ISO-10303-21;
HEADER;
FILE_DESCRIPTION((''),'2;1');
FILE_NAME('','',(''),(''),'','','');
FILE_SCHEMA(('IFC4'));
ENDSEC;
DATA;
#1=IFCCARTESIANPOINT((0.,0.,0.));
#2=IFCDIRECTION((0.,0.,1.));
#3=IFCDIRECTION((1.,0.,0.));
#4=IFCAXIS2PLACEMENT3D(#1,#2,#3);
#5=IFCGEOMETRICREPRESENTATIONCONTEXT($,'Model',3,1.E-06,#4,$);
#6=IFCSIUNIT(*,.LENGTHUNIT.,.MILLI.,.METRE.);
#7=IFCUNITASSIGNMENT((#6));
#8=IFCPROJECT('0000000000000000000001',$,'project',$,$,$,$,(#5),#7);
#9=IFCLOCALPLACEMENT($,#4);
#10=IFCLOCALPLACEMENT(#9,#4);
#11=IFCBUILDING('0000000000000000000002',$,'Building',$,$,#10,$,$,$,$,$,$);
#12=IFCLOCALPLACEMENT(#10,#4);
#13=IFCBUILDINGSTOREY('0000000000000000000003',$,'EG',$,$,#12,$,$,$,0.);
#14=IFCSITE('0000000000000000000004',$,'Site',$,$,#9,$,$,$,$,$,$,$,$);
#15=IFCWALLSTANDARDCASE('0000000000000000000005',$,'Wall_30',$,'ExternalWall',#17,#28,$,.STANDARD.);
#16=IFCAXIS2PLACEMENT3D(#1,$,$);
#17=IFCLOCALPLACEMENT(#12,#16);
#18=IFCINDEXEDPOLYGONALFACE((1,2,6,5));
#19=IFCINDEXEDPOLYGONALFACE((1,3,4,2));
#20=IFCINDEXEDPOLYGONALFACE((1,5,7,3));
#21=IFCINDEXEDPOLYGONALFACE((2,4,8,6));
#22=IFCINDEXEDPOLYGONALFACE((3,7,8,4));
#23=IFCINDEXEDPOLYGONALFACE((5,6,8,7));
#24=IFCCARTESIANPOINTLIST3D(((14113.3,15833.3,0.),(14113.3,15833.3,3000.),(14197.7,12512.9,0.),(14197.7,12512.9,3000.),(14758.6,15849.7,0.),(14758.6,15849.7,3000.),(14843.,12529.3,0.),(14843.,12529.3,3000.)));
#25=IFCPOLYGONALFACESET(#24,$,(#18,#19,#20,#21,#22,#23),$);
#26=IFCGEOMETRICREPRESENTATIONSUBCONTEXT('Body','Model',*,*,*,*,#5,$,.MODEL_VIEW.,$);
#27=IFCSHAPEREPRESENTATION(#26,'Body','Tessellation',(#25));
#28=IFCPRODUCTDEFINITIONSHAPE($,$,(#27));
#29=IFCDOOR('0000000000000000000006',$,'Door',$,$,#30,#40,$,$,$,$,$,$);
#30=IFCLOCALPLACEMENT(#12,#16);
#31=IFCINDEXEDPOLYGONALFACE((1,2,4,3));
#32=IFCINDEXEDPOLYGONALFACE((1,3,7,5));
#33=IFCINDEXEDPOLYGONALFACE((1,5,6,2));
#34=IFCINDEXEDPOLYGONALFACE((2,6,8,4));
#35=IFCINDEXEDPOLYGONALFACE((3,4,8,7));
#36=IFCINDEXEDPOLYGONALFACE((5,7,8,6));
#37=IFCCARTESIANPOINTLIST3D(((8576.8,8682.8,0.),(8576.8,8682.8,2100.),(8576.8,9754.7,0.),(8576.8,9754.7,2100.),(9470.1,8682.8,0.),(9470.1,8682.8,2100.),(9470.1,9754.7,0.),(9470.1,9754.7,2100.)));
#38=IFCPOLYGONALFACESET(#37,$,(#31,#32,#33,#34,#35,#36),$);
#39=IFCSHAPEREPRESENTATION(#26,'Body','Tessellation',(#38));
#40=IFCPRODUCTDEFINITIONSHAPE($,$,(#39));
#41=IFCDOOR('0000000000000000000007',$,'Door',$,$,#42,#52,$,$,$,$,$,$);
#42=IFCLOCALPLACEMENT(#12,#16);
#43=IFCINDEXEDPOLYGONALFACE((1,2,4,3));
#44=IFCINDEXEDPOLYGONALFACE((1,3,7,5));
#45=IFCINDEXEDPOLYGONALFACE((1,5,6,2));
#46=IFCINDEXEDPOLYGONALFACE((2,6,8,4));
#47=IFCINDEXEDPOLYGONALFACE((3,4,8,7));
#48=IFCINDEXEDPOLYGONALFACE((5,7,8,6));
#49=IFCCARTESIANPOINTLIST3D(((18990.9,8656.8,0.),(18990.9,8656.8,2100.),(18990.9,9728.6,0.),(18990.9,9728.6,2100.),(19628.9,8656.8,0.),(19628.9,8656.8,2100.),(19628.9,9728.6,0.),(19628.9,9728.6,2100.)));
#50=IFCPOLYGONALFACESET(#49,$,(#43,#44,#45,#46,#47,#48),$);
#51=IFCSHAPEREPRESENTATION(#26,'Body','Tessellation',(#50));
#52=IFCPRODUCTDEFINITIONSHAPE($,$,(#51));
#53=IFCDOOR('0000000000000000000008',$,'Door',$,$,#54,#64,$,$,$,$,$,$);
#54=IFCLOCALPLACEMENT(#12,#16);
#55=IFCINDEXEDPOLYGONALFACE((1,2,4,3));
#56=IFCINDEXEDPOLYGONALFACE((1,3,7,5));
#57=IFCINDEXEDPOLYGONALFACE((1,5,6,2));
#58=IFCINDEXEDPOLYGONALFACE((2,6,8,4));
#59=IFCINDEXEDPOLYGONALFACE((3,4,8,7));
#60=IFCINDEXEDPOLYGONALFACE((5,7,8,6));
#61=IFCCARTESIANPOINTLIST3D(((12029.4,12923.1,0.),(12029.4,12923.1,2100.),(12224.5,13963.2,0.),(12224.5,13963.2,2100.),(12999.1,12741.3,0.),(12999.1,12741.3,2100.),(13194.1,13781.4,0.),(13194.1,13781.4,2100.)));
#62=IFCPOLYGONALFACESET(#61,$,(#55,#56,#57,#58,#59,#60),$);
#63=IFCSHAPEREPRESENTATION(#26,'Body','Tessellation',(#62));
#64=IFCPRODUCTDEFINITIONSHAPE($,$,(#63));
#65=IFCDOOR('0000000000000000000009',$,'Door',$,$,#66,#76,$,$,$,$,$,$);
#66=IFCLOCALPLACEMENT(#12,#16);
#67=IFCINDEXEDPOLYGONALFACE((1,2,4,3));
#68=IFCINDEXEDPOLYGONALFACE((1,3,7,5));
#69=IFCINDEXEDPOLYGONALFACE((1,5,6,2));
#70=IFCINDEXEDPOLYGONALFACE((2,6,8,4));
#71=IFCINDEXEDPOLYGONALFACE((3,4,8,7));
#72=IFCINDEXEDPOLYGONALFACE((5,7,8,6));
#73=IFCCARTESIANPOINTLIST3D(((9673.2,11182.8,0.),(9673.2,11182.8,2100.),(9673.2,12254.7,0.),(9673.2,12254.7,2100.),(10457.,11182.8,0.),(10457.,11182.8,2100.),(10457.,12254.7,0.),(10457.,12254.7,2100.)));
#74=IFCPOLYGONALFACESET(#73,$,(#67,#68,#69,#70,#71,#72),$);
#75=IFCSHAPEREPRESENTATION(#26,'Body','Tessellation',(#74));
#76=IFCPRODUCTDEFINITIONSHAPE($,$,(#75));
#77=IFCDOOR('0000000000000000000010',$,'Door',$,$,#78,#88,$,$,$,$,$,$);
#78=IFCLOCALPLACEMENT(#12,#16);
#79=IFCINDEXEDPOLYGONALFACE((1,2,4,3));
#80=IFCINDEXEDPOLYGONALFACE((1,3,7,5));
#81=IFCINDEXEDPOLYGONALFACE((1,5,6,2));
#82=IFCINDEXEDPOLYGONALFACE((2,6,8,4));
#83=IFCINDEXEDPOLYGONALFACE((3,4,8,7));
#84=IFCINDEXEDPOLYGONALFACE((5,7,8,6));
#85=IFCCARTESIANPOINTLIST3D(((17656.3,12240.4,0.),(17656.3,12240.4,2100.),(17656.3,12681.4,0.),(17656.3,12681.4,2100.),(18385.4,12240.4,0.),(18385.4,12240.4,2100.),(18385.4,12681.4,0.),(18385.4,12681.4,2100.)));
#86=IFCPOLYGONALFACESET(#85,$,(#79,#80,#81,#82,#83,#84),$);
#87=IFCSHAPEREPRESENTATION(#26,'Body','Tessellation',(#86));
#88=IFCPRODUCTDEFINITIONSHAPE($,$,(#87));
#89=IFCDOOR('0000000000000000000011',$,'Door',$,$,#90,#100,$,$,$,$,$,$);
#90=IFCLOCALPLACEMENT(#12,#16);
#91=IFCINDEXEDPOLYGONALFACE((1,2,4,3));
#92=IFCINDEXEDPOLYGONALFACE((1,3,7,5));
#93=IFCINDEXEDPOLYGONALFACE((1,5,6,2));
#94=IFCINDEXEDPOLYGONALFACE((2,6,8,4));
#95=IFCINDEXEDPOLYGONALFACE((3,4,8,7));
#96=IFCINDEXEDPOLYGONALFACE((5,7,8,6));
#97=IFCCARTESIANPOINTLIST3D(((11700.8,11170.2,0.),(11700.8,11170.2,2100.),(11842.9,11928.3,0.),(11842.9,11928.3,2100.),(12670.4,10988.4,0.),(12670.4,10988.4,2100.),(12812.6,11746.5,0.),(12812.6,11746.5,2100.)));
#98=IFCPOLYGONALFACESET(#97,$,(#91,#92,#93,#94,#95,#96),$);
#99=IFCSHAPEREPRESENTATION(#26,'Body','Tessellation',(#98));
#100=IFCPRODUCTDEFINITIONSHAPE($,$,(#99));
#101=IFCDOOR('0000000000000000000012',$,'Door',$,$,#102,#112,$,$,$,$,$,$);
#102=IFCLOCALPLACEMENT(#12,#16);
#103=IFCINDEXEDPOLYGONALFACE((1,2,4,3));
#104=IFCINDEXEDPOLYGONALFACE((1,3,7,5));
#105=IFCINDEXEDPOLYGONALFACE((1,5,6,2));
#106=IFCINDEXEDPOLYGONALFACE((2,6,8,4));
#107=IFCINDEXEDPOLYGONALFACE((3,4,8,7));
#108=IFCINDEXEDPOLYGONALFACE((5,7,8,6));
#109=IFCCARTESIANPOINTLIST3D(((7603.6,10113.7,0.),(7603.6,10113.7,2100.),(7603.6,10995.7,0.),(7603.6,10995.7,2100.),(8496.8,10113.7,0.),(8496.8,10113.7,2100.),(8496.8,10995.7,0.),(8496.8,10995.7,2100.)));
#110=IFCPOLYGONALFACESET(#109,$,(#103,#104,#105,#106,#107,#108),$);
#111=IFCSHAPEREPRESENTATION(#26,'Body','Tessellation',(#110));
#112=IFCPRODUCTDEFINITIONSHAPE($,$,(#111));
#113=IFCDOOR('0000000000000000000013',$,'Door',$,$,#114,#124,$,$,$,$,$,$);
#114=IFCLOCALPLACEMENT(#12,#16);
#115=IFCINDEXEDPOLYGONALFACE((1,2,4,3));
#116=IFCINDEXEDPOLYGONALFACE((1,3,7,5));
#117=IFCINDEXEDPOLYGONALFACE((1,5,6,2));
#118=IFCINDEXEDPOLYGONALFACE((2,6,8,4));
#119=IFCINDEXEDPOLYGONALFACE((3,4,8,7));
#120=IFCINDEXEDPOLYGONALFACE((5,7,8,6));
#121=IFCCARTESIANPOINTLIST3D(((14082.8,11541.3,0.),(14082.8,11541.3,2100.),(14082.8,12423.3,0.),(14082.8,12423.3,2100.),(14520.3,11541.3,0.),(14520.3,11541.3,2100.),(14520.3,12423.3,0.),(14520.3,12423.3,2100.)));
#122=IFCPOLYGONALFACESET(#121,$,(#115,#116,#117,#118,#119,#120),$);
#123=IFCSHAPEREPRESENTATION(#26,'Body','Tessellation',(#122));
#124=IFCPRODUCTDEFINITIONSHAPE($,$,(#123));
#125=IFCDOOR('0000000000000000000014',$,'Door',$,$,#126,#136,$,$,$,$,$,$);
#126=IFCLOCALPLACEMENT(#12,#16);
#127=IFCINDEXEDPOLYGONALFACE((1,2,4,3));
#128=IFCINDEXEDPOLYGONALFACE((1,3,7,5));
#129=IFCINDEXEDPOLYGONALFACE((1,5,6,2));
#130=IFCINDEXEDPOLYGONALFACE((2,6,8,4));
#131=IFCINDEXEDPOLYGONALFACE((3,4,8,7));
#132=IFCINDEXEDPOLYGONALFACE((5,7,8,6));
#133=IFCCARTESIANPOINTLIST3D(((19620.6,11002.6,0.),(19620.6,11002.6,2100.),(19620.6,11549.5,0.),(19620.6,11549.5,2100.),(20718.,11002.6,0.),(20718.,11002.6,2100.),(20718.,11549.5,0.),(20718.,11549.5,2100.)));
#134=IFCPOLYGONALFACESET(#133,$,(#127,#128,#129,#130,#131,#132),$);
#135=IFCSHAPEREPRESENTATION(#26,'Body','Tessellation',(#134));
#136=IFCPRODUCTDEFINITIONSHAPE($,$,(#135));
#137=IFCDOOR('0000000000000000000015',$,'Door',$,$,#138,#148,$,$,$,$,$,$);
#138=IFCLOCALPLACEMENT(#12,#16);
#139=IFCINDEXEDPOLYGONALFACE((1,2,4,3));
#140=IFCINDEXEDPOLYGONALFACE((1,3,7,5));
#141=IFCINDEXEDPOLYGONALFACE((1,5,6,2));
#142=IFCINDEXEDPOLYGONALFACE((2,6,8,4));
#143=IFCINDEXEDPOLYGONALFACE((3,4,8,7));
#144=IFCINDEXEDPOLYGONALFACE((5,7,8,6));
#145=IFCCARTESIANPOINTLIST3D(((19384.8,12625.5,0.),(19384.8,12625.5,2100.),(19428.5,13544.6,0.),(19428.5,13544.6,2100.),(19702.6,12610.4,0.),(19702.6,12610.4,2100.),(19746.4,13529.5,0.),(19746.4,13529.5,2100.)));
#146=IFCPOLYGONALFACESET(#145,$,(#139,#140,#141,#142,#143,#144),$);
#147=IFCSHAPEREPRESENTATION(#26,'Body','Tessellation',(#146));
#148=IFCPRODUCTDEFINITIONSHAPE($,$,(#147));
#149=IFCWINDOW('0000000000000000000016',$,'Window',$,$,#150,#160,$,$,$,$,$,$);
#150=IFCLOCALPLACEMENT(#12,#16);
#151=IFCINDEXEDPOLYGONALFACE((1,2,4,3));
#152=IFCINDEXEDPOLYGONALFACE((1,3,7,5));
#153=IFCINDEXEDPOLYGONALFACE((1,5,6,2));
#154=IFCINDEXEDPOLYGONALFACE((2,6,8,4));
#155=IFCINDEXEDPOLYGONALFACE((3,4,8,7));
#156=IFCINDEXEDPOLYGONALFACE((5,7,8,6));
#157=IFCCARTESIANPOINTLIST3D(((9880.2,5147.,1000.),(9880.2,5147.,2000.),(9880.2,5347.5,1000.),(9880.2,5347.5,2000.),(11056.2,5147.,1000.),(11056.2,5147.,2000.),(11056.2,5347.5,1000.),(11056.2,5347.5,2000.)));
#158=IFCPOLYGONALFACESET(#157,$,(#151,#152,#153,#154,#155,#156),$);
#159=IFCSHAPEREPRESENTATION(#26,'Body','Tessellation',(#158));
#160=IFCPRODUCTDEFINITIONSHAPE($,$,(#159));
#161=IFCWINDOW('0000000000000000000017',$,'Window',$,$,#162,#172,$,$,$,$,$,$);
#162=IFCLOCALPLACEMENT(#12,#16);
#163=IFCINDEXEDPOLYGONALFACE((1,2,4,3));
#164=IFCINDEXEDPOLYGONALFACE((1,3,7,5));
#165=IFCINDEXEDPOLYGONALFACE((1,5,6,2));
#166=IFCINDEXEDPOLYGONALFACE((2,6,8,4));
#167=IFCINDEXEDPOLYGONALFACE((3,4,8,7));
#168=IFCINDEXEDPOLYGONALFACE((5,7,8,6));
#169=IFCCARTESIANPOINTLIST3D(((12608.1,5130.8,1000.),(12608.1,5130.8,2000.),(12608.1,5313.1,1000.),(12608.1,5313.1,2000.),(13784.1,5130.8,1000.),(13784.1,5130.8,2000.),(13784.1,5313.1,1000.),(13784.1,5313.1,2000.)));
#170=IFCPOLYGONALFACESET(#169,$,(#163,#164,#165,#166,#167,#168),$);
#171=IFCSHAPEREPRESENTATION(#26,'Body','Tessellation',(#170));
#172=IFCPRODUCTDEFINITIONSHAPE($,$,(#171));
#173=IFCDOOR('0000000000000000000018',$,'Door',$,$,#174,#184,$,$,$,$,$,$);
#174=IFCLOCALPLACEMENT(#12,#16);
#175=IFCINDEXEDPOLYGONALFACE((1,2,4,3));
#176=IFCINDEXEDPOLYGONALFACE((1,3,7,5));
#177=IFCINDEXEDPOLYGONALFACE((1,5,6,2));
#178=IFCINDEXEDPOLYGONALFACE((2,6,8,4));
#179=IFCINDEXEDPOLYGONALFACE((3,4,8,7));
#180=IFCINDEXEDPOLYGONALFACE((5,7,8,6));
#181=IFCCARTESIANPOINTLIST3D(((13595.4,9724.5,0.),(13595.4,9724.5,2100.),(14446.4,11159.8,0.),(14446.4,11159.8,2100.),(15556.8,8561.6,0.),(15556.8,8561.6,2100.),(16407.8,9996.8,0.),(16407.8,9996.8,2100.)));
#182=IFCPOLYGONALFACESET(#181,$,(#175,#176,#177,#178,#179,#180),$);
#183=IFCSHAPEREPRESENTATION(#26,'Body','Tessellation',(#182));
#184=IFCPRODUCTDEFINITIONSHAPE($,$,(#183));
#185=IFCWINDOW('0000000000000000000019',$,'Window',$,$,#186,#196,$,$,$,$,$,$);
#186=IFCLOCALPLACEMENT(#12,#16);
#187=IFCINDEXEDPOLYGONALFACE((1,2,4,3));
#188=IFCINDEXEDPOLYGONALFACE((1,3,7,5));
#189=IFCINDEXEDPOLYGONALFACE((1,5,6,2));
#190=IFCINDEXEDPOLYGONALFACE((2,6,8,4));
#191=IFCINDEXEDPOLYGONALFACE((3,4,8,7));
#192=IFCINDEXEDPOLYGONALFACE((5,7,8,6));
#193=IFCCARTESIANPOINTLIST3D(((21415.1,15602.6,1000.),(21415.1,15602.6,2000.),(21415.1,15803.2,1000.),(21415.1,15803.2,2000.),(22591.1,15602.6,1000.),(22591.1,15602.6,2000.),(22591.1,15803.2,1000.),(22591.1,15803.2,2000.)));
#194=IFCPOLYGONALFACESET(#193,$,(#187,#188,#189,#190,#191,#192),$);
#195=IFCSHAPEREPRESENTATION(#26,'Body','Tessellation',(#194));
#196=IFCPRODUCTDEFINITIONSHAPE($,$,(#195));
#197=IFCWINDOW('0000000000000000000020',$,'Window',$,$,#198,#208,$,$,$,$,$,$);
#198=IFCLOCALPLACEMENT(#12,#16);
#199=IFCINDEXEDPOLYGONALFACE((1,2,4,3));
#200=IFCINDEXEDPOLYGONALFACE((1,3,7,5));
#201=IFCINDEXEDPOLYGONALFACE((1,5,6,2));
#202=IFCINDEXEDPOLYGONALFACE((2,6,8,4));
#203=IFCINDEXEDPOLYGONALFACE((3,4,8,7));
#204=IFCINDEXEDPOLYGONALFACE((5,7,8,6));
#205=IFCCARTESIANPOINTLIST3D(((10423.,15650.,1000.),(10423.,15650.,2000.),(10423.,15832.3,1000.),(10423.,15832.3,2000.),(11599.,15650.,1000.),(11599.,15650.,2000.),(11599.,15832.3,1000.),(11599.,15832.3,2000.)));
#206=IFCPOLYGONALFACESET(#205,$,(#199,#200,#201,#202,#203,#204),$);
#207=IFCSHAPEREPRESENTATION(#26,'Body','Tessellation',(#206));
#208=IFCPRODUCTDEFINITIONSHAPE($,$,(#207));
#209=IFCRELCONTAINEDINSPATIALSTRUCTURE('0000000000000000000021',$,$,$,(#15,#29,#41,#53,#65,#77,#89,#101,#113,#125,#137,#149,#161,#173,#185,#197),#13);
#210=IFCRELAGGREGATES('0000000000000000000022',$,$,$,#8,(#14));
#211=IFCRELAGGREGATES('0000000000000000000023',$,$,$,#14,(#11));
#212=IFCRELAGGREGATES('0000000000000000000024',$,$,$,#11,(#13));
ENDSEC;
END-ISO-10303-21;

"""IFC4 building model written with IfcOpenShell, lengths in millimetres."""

from ifc_helpers import new_model, si_unit, frame, origin_with_axes, place, context, subcontext, project, spatial, rectangle, extrude, element, save


model = new_model("IFC4")

# Units and contexts
model_context = context("Model", 3, precision=1e-06, world=origin_with_axes())
body_context = subcontext(model_context, "Body", "Model", "MODEL_VIEW")
ifc_project = project(units=[si_unit("LENGTHUNIT", "METRE", prefix="MILLI")], contexts=[model_context])

# Site, building, storey
site_placement = place(None, origin_with_axes())
site = spatial("IfcSite", under=ifc_project, at=site_placement, Name="Site")
building_placement = place(site_placement, origin_with_axes())
building = spatial("IfcBuilding", under=site, at=building_placement, Name="Building")
storey_placement = place(building_placement, origin_with_axes())
storey = spatial("IfcBuildingStorey", under=building, at=storey_placement, Name="EG", Elevation=0.0)

# Wall
wall_placement = place(storey_placement, origin_with_axes())
element("IfcWallStandardCase", 1, at=wall_placement, inside=storey, Name="Wall_30", ObjectType="ExternalWall", PredefinedType="STANDARD", context=body_context, shape_type="SweptSolid", body=[
    extrude(rectangle(XDim=3321.4, YDim=645.5), frame((14478.1, 14181.3, 0.0), z_axis=(0.0, 0.0, 1.0), x_axis=(0.025416, -0.999677, 0.0)), (0.0, 0.0, 1.0), 3000.0),
])

# Doors
door_1_placement = place(storey_placement, origin_with_axes())
element("IfcDoor", 2, at=door_1_placement, inside=storey, Name="Door", context=body_context, shape_type="SweptSolid", body=[
    extrude(rectangle(XDim=1071.9, YDim=893.2), frame((9023.4, 9218.8, 0.0), z_axis=(0.0, 0.0, 1.0), x_axis=(0.0, 1.0, 0.0)), (0.0, 0.0, 1.0), 2100.0),
])
door_2_placement = place(storey_placement, origin_with_axes())
element("IfcDoor", 3, at=door_2_placement, inside=storey, Name="Door", context=body_context, shape_type="SweptSolid", body=[
    extrude(rectangle(XDim=1071.9, YDim=638.0), frame((19309.9, 9192.7, 0.0), z_axis=(0.0, 0.0, 1.0), x_axis=(0.0, 1.0, 0.0)), (0.0, 0.0, 1.0), 2100.0),
])
door_3_placement = place(storey_placement, origin_with_axes())
element("IfcDoor", 4, at=door_3_placement, inside=storey, Name="Door", context=body_context, shape_type="SweptSolid", body=[
    extrude(rectangle(XDim=1058.2, YDim=986.6), frame((12611.8, 13352.3, 0.0), z_axis=(0.0, 0.0, 1.0), x_axis=(0.184288, 0.982872, 0.0)), (0.0, 0.0, 1.0), 2100.0),
])
door_4_placement = place(storey_placement, origin_with_axes())
element("IfcDoor", 5, at=door_4_placement, inside=storey, Name="Door", context=body_context, shape_type="SweptSolid", body=[
    extrude(rectangle(XDim=1071.9, YDim=783.9), frame((10065.1, 11718.8, 0.0), z_axis=(0.0, 0.0, 1.0), x_axis=(0.0, -1.0, 0.0)), (0.0, 0.0, 1.0), 2100.0),
])
door_5_placement = place(storey_placement, origin_with_axes())
element("IfcDoor", 6, at=door_5_placement, inside=storey, Name="Door", context=body_context, shape_type="SweptSolid", body=[
    extrude(rectangle(XDim=441.0, YDim=729.2), frame((18020.8, 12460.9, 0.0), z_axis=(0.0, 0.0, 1.0), x_axis=(0.0, 1.0, 0.0)), (0.0, 0.0, 1.0), 2100.0),
])
door_6_placement = place(storey_placement, origin_with_axes())
element("IfcDoor", 7, at=door_6_placement, inside=storey, Name="Door", context=body_context, shape_type="SweptSolid", body=[
    extrude(rectangle(XDim=771.3, YDim=986.6), frame((12256.7, 11458.4, 0.0), z_axis=(0.0, 0.0, 1.0), x_axis=(0.184288, 0.982872, 0.0)), (0.0, 0.0, 1.0), 2100.0),
])
door_7_placement = place(storey_placement, origin_with_axes())
element("IfcDoor", 8, at=door_7_placement, inside=storey, Name="Door", context=body_context, shape_type="SweptSolid", body=[
    extrude(rectangle(XDim=882.0, YDim=893.2), frame((8050.2, 10554.7, 0.0), z_axis=(0.0, 0.0, 1.0), x_axis=(0.0, 1.0, 0.0)), (0.0, 0.0, 1.0), 2100.0),
])
door_8_placement = place(storey_placement, origin_with_axes())
element("IfcDoor", 9, at=door_8_placement, inside=storey, Name="Door", context=body_context, shape_type="SweptSolid", body=[
    extrude(rectangle(XDim=882.0, YDim=437.5), frame((14301.5, 11982.3, 0.0), z_axis=(0.0, 0.0, 1.0), x_axis=(0.0, 1.0, 0.0)), (0.0, 0.0, 1.0), 2100.0),
])
door_9_placement = place(storey_placement, origin_with_axes())
element("IfcDoor", 10, at=door_9_placement, inside=storey, Name="Door", context=body_context, shape_type="SweptSolid", body=[
    extrude(rectangle(XDim=1097.4, YDim=546.9), frame((20169.3, 11276.0, 0.0), z_axis=(0.0, 0.0, 1.0), x_axis=(1.0, 0.0, 0.0)), (0.0, 0.0, 1.0), 2100.0),
])
door_10_placement = place(storey_placement, origin_with_axes())
element("IfcDoor", 11, at=door_10_placement, inside=storey, Name="Door", context=body_context, shape_type="SweptSolid", body=[
    extrude(rectangle(XDim=920.1, YDim=318.2), frame((19565.6, 13077.5, 0.0), z_axis=(0.0, 0.0, 1.0), x_axis=(-0.047565, -0.998868, 0.0)), (0.0, 0.0, 1.0), 2100.0),
])

# Windows
window_1_placement = place(storey_placement, origin_with_axes())
element("IfcWindow", 12, at=window_1_placement, inside=storey, Name="Window", context=body_context, shape_type="SweptSolid", body=[
    extrude(rectangle(XDim=1176.0, YDim=200.5), frame((10468.2, 5247.3, 1000.0), z_axis=(0.0, 0.0, 1.0), x_axis=(-1.0, 0.0, 0.0)), (0.0, 0.0, 1.0), 1000.0),
])
window_2_placement = place(storey_placement, origin_with_axes())
element("IfcWindow", 13, at=window_2_placement, inside=storey, Name="Window", context=body_context, shape_type="SweptSolid", body=[
    extrude(rectangle(XDim=1176.0, YDim=182.3), frame((13196.1, 5222.0, 1000.0), z_axis=(0.0, 0.0, 1.0), x_axis=(1.0, 0.0, 0.0)), (0.0, 0.0, 1.0), 1000.0),
])

# Door
door_11_placement = place(storey_placement, origin_with_axes())
element("IfcDoor", 14, at=door_11_placement, inside=storey, Name="Door", context=body_context, shape_type="SweptSolid", body=[
    extrude(rectangle(XDim=1668.6, YDim=2280.3), frame((15001.6, 9860.7, 0.0), z_axis=(0.0, 0.0, 1.0), x_axis=(-0.510011, -0.860168, 0.0)), (0.0, 0.0, 1.0), 2100.0),
])

# Windows
window_3_placement = place(storey_placement, origin_with_axes())
element("IfcWindow", 15, at=window_3_placement, inside=storey, Name="Window", context=body_context, shape_type="SweptSolid", body=[
    extrude(rectangle(XDim=1176.0, YDim=200.5), frame((22003.1, 15702.9, 1000.0), z_axis=(0.0, 0.0, 1.0), x_axis=(1.0, 0.0, 0.0)), (0.0, 0.0, 1.0), 1000.0),
])
window_4_placement = place(storey_placement, origin_with_axes())
element("IfcWindow", 16, at=window_4_placement, inside=storey, Name="Window", context=body_context, shape_type="SweptSolid", body=[
    extrude(rectangle(XDim=1176.0, YDim=182.3), frame((11011.0, 15741.2, 1000.0), z_axis=(0.0, 0.0, 1.0), x_axis=(1.0, 0.0, 0.0)), (0.0, 0.0, 1.0), 1000.0),
])

save(model, "model.ifc")
